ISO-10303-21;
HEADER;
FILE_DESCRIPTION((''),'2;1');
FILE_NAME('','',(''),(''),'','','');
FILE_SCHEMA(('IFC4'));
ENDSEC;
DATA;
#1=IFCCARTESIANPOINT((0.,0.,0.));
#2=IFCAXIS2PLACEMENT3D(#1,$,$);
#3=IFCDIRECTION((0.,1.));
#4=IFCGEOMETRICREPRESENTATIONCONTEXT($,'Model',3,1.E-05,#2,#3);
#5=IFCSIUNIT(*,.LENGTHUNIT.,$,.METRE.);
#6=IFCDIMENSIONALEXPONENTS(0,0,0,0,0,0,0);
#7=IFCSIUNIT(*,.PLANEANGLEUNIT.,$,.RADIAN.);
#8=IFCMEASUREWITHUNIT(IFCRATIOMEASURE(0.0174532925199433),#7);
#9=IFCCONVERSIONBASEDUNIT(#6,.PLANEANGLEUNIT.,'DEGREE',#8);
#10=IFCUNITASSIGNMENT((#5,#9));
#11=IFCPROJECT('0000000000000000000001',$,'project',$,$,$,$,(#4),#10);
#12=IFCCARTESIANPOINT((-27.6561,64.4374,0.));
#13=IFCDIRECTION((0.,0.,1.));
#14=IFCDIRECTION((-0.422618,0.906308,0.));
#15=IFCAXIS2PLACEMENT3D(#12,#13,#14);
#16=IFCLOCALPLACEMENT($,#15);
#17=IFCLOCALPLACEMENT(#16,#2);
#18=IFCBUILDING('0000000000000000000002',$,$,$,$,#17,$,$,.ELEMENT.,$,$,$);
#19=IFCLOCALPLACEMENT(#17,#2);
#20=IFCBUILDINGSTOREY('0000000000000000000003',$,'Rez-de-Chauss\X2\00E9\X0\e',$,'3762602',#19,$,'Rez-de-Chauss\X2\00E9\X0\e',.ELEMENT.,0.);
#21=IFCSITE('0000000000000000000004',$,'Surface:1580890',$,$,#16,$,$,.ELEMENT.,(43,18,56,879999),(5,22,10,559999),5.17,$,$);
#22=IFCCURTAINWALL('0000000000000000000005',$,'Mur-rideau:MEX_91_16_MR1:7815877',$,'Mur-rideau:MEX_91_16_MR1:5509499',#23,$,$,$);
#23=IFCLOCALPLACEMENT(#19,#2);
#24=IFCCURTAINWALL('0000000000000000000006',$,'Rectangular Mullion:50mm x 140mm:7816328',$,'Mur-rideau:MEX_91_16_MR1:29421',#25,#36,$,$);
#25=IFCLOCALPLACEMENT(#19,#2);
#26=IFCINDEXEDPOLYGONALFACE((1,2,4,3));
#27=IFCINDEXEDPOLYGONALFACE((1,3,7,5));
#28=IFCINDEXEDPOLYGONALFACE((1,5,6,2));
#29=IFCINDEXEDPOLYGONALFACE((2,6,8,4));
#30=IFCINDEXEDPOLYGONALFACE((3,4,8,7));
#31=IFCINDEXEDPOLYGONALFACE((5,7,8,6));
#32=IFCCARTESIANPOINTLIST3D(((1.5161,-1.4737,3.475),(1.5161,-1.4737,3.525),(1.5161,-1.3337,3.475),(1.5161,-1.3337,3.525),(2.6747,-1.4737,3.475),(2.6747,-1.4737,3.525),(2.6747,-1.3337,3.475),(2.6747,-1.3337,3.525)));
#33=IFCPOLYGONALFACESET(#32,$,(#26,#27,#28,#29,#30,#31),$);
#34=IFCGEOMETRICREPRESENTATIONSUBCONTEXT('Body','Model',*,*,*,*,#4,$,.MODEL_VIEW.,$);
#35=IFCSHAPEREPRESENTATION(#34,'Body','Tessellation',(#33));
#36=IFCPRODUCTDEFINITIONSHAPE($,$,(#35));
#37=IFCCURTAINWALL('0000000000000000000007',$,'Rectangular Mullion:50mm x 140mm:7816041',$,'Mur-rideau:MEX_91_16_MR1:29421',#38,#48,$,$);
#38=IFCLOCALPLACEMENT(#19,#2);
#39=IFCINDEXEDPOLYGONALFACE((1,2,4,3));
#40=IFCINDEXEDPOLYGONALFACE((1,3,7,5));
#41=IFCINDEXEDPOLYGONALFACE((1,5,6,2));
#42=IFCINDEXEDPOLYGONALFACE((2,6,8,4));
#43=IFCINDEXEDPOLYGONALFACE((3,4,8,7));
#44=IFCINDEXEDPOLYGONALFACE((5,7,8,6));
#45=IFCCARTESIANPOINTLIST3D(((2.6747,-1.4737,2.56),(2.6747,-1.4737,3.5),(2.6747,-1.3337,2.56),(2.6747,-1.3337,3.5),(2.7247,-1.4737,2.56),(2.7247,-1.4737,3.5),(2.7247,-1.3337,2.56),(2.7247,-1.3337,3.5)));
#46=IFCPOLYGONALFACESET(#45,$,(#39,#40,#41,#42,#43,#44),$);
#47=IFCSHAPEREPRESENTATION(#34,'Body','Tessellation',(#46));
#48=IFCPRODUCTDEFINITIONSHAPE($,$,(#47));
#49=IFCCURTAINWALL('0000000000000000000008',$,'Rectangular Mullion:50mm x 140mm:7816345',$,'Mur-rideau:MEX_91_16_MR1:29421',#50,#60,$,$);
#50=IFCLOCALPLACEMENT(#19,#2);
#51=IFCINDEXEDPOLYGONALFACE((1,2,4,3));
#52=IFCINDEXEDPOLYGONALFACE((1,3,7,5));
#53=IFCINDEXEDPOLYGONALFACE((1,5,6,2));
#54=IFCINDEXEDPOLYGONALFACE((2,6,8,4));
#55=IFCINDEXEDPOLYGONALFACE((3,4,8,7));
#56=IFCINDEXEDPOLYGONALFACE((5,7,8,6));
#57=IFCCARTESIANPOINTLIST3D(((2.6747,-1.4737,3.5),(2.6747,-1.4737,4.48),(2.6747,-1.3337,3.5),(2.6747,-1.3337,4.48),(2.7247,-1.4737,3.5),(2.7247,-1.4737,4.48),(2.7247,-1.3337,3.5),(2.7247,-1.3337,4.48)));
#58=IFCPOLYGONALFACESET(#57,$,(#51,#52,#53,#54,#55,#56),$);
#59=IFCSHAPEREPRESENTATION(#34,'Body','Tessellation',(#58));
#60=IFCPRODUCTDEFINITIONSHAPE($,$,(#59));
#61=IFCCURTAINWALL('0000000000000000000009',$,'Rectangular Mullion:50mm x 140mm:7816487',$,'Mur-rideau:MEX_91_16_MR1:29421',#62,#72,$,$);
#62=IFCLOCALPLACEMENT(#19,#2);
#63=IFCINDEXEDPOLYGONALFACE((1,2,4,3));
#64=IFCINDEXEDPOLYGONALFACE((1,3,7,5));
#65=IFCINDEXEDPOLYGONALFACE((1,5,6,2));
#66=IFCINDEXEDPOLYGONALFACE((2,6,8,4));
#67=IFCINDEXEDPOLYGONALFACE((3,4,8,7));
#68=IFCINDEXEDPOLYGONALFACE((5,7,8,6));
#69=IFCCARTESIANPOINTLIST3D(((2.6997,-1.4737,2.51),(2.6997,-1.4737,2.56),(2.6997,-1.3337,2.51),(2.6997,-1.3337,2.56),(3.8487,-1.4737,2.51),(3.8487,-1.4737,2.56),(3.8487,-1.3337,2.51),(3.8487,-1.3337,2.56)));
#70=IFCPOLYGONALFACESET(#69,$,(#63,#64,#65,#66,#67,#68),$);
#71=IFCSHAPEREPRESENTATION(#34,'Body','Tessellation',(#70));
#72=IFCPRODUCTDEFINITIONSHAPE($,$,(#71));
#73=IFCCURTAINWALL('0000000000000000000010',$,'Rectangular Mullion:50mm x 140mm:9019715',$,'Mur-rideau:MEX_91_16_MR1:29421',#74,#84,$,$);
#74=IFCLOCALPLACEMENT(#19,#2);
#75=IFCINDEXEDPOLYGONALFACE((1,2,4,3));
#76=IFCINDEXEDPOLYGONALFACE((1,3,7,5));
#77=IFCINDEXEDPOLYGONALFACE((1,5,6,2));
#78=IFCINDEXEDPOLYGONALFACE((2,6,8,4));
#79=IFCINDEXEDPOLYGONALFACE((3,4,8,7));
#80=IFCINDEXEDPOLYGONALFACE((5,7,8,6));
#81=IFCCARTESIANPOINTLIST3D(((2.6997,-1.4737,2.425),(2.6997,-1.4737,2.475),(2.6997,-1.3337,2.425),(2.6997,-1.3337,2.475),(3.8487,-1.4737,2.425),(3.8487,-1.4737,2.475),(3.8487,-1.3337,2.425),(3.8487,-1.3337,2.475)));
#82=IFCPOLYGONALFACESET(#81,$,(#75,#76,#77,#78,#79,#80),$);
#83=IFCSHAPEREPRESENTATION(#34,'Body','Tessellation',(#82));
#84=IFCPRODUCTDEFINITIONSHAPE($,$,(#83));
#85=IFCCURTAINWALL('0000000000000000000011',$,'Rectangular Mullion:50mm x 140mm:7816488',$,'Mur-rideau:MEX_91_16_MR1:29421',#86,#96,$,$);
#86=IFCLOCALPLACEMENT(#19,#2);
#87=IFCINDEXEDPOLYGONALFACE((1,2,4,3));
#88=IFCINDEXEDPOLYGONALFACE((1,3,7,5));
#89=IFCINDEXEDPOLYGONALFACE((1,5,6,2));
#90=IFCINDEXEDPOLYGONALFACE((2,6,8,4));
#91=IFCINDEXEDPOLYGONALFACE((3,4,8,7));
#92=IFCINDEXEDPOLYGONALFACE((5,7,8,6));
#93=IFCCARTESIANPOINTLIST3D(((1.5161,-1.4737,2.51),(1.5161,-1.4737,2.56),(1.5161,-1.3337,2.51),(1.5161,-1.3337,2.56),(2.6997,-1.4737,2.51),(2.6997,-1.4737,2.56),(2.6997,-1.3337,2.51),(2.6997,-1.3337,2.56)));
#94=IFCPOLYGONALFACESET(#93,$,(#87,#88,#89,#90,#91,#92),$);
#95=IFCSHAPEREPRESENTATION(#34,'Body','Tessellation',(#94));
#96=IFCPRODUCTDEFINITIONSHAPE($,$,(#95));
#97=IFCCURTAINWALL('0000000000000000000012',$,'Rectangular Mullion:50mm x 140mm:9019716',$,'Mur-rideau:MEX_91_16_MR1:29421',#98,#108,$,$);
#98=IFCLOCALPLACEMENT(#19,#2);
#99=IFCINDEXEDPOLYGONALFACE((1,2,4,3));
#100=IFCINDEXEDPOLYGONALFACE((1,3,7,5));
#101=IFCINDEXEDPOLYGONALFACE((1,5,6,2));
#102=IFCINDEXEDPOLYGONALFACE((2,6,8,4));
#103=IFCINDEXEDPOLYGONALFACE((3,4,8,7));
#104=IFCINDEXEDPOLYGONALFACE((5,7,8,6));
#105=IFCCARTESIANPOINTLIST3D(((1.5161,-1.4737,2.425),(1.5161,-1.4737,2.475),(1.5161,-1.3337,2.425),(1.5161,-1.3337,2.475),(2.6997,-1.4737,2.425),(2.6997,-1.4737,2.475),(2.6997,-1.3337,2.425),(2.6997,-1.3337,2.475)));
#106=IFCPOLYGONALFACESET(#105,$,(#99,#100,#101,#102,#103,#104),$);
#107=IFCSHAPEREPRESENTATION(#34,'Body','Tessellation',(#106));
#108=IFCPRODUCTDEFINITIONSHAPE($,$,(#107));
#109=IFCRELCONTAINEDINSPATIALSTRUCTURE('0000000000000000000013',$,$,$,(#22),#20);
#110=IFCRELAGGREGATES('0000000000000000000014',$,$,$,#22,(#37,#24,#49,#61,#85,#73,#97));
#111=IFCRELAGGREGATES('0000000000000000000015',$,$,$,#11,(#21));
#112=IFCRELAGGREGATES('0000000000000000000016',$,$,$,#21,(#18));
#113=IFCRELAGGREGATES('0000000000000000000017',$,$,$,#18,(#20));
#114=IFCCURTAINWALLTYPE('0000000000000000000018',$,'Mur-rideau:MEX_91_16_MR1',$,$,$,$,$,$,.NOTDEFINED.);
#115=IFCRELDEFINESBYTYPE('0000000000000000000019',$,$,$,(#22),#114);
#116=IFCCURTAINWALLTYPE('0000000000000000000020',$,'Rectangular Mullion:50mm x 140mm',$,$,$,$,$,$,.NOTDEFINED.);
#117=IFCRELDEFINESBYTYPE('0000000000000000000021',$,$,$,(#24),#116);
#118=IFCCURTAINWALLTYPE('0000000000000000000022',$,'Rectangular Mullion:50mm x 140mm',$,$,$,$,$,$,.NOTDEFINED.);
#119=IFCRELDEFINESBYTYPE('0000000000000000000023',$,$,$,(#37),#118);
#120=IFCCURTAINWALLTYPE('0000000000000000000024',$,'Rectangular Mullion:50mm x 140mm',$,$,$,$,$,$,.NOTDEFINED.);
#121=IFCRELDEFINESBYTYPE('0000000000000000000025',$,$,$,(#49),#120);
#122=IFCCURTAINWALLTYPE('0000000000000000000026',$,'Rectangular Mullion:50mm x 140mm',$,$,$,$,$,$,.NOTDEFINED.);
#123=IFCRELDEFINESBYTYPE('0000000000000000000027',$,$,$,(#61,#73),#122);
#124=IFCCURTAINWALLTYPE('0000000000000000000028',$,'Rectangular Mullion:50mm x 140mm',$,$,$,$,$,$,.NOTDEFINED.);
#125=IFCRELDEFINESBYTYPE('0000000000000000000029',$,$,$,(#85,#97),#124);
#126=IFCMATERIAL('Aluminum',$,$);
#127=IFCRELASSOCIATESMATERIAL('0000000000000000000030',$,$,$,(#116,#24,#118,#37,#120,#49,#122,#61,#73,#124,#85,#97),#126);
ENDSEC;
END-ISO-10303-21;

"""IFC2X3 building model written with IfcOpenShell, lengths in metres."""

from ifc_helpers import new_model, entity, si_unit, converted_unit, direction, frame, origin, origin_2d_with_axis, place, context, subcontext, project, spatial, rectangle, extrude, source, transform, mapped, material, type_object, type_shapes, element, aggregate, save


model = new_model("IFC2X3")

# Units and contexts
model_context = context("Model", 3, precision=1e-05, world=origin(), true_north=direction((0.0, 1.0)))
body_context = subcontext(model_context, "Body", "Model", "MODEL_VIEW")
ifc_project = project(units=[si_unit("LENGTHUNIT", "METRE"), converted_unit("PLANEANGLEUNIT", "DEGREE", entity("IfcRatioMeasure", 0.0174532925199433), si_unit("PLANEANGLEUNIT", "RADIAN"), dimensions=[0, 0, 0, 0, 0, 0, 0])], contexts=[model_context])

# Site, building, storey
site_placement = place(None, frame((-27.6561, 64.4374, 0.0), z_axis=(0.0, 0.0, 1.0), x_axis=(-0.422618, 0.906308, 0.0)))
site = spatial("IfcSite", under=ifc_project, at=site_placement, Name="Surface:1580890", CompositionType="ELEMENT", RefLatitude=(43, 18, 56, 879999), RefLongitude=(5, 22, 10, 559999), RefElevation=5.17)
building_placement = place(site_placement, origin())
building = spatial("IfcBuilding", under=site, at=building_placement, CompositionType="ELEMENT")
storey_placement = place(building_placement, origin())
storey = spatial("IfcBuildingStorey", under=building, at=storey_placement, Name="Rez-de-Chaussée", ObjectType="3762602", LongName="Rez-de-Chaussée", CompositionType="ELEMENT", Elevation=0.0)

# Curtain walls
curtain_wall_type_1 = type_object("IfcCurtainWallType", Name="Mur-rideau:MEX_91_16_MR1", PredefinedType="NOTDEFINED")
curtain_wall_1_placement = place(storey_placement, origin())
curtain_wall_1 = element("IfcCurtainWall", 1, at=curtain_wall_1_placement, inside=storey, type_object=curtain_wall_type_1, Name="Mur-rideau:MEX_91_16_MR1:7815877", ObjectType="Mur-rideau:MEX_91_16_MR1:5509499")
ifc_material_1 = material(Name="Aluminum")
curtain_wall_type_2 = type_object("IfcCurtainWallType", Name="Rectangular Mullion:50mm x 140mm", PredefinedType="NOTDEFINED", material=ifc_material_1)
shared_shape_1 = source(origin(), body_context, "Body", "SweptSolid", [
    extrude(rectangle(XDim=0.05, YDim=0.14, at=origin_2d_with_axis()), frame((0.0, 0.0, -1.1586), z_axis=(0.0, 0.0, 1.0), x_axis=(-1.0, 0.0, 0.0)), (0.0, 0.0, 1.0), 1.1586),
])
type_shapes(curtain_wall_type_2, [shared_shape_1])
curtain_wall_2_placement = place(storey_placement, frame((1.5161, -1.4037, 3.5), z_axis=(-1.0, 0.0, 0.0), x_axis=(0.0, 0.0, 1.0)))
curtain_wall_2 = element("IfcCurtainWall", 2, at=curtain_wall_2_placement, type_object=curtain_wall_type_2, material=ifc_material_1, Name="Rectangular Mullion:50mm x 140mm:7816328", ObjectType="Mur-rideau:MEX_91_16_MR1:29421", context=body_context, shape_type="MappedRepresentation", body=[
    mapped(shared_shape_1, transform((0.0, 0.0, 0.0), scale=1.0)),
])
curtain_wall_type_3 = type_object("IfcCurtainWallType", Name="Rectangular Mullion:50mm x 140mm", PredefinedType="NOTDEFINED", material=ifc_material_1)
shared_shape_2 = source(origin(), body_context, "Body", "SweptSolid", [
    extrude(rectangle(XDim=0.05, YDim=0.14, at=origin_2d_with_axis()), frame((0.0, 0.0, -0.94), z_axis=(0.0, 0.0, 1.0), x_axis=(-1.0, 0.0, 0.0)), (0.0, 0.0, 1.0), 0.94),
])
type_shapes(curtain_wall_type_3, [shared_shape_2])
curtain_wall_3_placement = place(storey_placement, frame((2.6997, -1.4037, 2.56), z_axis=(0.0, 0.0, -1.0), x_axis=(-1.0, 0.0, 0.0)))
curtain_wall_3 = element("IfcCurtainWall", 3, at=curtain_wall_3_placement, type_object=curtain_wall_type_3, material=ifc_material_1, Name="Rectangular Mullion:50mm x 140mm:7816041", ObjectType="Mur-rideau:MEX_91_16_MR1:29421", context=body_context, shape_type="MappedRepresentation", body=[
    mapped(shared_shape_2, transform((0.0, 0.0, 0.0), scale=1.0)),
])
curtain_wall_type_4 = type_object("IfcCurtainWallType", Name="Rectangular Mullion:50mm x 140mm", PredefinedType="NOTDEFINED", material=ifc_material_1)
shared_shape_3 = source(origin(), body_context, "Body", "SweptSolid", [
    extrude(rectangle(XDim=0.05, YDim=0.14, at=origin_2d_with_axis()), frame((0.0, 0.0, -0.98), z_axis=(0.0, 0.0, 1.0), x_axis=(-1.0, 0.0, 0.0)), (0.0, 0.0, 1.0), 0.98),
])
type_shapes(curtain_wall_type_4, [shared_shape_3])
curtain_wall_4_placement = place(storey_placement, frame((2.6997, -1.4037, 3.5), z_axis=(0.0, 0.0, -1.0), x_axis=(-1.0, 0.0, 0.0)))
curtain_wall_4 = element("IfcCurtainWall", 4, at=curtain_wall_4_placement, type_object=curtain_wall_type_4, material=ifc_material_1, Name="Rectangular Mullion:50mm x 140mm:7816345", ObjectType="Mur-rideau:MEX_91_16_MR1:29421", context=body_context, shape_type="MappedRepresentation", body=[
    mapped(shared_shape_3, transform((0.0, 0.0, 0.0), scale=1.0)),
])
curtain_wall_type_5 = type_object("IfcCurtainWallType", Name="Rectangular Mullion:50mm x 140mm", PredefinedType="NOTDEFINED", material=ifc_material_1)
shared_shape_4 = source(origin(), body_context, "Body", "SweptSolid", [
    extrude(rectangle(XDim=0.05, YDim=0.14, at=origin_2d_with_axis()), frame((0.0, 0.0, -1.149), z_axis=(0.0, 0.0, 1.0), x_axis=(-1.0, 0.0, 0.0)), (0.0, 0.0, 1.0), 1.149),
])
type_shapes(curtain_wall_type_5, [shared_shape_4])
curtain_wall_5_placement = place(storey_placement, frame((2.6997, -1.4037, 2.535), z_axis=(-1.0, 0.0, 0.0), x_axis=(0.0, 0.0, 1.0)))
curtain_wall_5 = element("IfcCurtainWall", 5, at=curtain_wall_5_placement, type_object=curtain_wall_type_5, material=ifc_material_1, Name="Rectangular Mullion:50mm x 140mm:7816487", ObjectType="Mur-rideau:MEX_91_16_MR1:29421", context=body_context, shape_type="MappedRepresentation", body=[
    mapped(shared_shape_4, transform((0.0, 0.0, 0.0), scale=1.0)),
])
curtain_wall_6_placement = place(storey_placement, frame((2.6997, -1.4037, 2.45), z_axis=(-1.0, 0.0, 0.0), x_axis=(0.0, 0.0, 1.0)))
curtain_wall_6 = element("IfcCurtainWall", 6, at=curtain_wall_6_placement, type_object=curtain_wall_type_5, material=ifc_material_1, Name="Rectangular Mullion:50mm x 140mm:9019715", ObjectType="Mur-rideau:MEX_91_16_MR1:29421", context=body_context, shape_type="MappedRepresentation", body=[
    mapped(shared_shape_4, transform((0.0, 0.0, 0.0), scale=1.0)),
])
curtain_wall_type_6 = type_object("IfcCurtainWallType", Name="Rectangular Mullion:50mm x 140mm", PredefinedType="NOTDEFINED", material=ifc_material_1)
shared_shape_5 = source(origin(), body_context, "Body", "SweptSolid", [
    extrude(rectangle(XDim=0.05, YDim=0.14, at=origin_2d_with_axis()), frame((0.0, 0.0, -1.1836), z_axis=(0.0, 0.0, 1.0), x_axis=(-1.0, 0.0, 0.0)), (0.0, 0.0, 1.0), 1.1836),
])
type_shapes(curtain_wall_type_6, [shared_shape_5])
curtain_wall_7_placement = place(storey_placement, frame((1.5161, -1.4037, 2.535), z_axis=(-1.0, 0.0, 0.0), x_axis=(0.0, 0.0, 1.0)))
curtain_wall_7 = element("IfcCurtainWall", 7, at=curtain_wall_7_placement, type_object=curtain_wall_type_6, material=ifc_material_1, Name="Rectangular Mullion:50mm x 140mm:7816488", ObjectType="Mur-rideau:MEX_91_16_MR1:29421", context=body_context, shape_type="MappedRepresentation", body=[
    mapped(shared_shape_5, transform((0.0, 0.0, 0.0), scale=1.0)),
])
curtain_wall_8_placement = place(storey_placement, frame((1.5161, -1.4037, 2.45), z_axis=(-1.0, 0.0, 0.0), x_axis=(0.0, 0.0, 1.0)))
curtain_wall_8 = element("IfcCurtainWall", 8, at=curtain_wall_8_placement, type_object=curtain_wall_type_6, material=ifc_material_1, Name="Rectangular Mullion:50mm x 140mm:9019716", ObjectType="Mur-rideau:MEX_91_16_MR1:29421", context=body_context, shape_type="MappedRepresentation", body=[
    mapped(shared_shape_5, transform((0.0, 0.0, 0.0), scale=1.0)),
])
aggregate(curtain_wall_1, [curtain_wall_3, curtain_wall_2, curtain_wall_4, curtain_wall_5, curtain_wall_7, curtain_wall_6, curtain_wall_8])

save(model, "model.ifc")
